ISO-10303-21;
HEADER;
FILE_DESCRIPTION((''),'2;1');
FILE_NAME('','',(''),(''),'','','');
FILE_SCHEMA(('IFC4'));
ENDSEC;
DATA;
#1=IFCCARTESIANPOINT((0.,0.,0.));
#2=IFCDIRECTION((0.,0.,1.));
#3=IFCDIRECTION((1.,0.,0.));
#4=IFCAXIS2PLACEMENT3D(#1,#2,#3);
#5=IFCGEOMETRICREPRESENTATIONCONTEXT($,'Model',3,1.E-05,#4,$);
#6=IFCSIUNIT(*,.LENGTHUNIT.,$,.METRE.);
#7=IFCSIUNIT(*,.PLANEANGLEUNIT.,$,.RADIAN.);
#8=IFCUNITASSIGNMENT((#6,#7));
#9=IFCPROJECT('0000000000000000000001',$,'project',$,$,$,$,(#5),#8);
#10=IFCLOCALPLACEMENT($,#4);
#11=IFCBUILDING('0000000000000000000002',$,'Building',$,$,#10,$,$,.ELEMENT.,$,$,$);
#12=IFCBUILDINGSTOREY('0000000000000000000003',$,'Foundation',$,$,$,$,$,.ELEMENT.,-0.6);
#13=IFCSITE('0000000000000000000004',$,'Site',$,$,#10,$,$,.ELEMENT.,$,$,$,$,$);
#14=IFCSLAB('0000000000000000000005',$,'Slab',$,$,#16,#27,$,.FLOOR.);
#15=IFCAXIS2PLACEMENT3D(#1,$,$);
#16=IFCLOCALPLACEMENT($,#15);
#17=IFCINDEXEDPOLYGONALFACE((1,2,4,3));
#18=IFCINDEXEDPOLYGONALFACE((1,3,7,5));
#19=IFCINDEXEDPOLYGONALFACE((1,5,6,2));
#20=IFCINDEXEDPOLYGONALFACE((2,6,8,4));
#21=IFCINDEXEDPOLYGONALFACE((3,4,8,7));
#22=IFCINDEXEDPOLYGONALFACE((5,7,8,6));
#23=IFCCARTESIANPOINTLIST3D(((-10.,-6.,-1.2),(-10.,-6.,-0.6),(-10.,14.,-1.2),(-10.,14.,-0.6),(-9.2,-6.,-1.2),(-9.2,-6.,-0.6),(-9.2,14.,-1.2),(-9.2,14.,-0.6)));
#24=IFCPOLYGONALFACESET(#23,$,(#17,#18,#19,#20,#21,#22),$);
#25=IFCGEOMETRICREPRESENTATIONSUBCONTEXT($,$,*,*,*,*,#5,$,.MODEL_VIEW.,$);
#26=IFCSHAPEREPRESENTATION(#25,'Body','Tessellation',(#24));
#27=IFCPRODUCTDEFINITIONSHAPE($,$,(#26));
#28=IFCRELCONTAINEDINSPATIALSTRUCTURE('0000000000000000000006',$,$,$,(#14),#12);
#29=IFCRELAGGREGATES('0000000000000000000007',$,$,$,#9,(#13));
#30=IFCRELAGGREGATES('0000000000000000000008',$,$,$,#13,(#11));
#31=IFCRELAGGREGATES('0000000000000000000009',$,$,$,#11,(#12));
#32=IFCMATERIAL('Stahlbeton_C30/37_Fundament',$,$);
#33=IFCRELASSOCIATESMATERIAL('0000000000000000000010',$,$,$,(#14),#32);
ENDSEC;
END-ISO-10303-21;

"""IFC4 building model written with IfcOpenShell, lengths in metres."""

from ifc_helpers import new_model, si_unit, frame, frame_2d, origin, origin_with_axes, place, context, subcontext, project, spatial, rectangle, extrude, material, element, save


model = new_model("IFC4")

# Units and contexts
model_context = context("Model", 3, precision=1e-05, world=origin_with_axes())
sub_context = subcontext(model_context, None, None, "MODEL_VIEW")
ifc_project = project(units=[si_unit("LENGTHUNIT", "METRE"), si_unit("PLANEANGLEUNIT", "RADIAN")], contexts=[model_context])

# Site, building, storey
placement_1 = place(None, origin_with_axes())
site = spatial("IfcSite", under=ifc_project, at=placement_1, Name="Site", CompositionType="ELEMENT")
building = spatial("IfcBuilding", under=site, at=placement_1, Name="Building", CompositionType="ELEMENT")
storey = spatial("IfcBuildingStorey", under=building, Name="Foundation", CompositionType="ELEMENT", Elevation=-0.6)

# Slab
ifc_material = material(Name="Stahlbeton_C30/37_Fundament")
placement_2 = place(None, origin_with_axes())
placement_3 = place(placement_2, frame((0.0, 0.0, -0.6)))
slab_placement = place(placement_3, frame((-10.0, -6.0, -0.6)))
element("IfcSlab", 1, at=slab_placement, inside=storey, material=ifc_material, Name="Slab", PredefinedType="FLOOR", context=sub_context, shape_type="SweptSolid", body=[
    extrude(rectangle(XDim=0.8, YDim=20.0, at=frame_2d((0.4, 10.0))), origin(), (0.0, 0.0, 1.0), 0.6),
])

save(model, "model.ifc")
